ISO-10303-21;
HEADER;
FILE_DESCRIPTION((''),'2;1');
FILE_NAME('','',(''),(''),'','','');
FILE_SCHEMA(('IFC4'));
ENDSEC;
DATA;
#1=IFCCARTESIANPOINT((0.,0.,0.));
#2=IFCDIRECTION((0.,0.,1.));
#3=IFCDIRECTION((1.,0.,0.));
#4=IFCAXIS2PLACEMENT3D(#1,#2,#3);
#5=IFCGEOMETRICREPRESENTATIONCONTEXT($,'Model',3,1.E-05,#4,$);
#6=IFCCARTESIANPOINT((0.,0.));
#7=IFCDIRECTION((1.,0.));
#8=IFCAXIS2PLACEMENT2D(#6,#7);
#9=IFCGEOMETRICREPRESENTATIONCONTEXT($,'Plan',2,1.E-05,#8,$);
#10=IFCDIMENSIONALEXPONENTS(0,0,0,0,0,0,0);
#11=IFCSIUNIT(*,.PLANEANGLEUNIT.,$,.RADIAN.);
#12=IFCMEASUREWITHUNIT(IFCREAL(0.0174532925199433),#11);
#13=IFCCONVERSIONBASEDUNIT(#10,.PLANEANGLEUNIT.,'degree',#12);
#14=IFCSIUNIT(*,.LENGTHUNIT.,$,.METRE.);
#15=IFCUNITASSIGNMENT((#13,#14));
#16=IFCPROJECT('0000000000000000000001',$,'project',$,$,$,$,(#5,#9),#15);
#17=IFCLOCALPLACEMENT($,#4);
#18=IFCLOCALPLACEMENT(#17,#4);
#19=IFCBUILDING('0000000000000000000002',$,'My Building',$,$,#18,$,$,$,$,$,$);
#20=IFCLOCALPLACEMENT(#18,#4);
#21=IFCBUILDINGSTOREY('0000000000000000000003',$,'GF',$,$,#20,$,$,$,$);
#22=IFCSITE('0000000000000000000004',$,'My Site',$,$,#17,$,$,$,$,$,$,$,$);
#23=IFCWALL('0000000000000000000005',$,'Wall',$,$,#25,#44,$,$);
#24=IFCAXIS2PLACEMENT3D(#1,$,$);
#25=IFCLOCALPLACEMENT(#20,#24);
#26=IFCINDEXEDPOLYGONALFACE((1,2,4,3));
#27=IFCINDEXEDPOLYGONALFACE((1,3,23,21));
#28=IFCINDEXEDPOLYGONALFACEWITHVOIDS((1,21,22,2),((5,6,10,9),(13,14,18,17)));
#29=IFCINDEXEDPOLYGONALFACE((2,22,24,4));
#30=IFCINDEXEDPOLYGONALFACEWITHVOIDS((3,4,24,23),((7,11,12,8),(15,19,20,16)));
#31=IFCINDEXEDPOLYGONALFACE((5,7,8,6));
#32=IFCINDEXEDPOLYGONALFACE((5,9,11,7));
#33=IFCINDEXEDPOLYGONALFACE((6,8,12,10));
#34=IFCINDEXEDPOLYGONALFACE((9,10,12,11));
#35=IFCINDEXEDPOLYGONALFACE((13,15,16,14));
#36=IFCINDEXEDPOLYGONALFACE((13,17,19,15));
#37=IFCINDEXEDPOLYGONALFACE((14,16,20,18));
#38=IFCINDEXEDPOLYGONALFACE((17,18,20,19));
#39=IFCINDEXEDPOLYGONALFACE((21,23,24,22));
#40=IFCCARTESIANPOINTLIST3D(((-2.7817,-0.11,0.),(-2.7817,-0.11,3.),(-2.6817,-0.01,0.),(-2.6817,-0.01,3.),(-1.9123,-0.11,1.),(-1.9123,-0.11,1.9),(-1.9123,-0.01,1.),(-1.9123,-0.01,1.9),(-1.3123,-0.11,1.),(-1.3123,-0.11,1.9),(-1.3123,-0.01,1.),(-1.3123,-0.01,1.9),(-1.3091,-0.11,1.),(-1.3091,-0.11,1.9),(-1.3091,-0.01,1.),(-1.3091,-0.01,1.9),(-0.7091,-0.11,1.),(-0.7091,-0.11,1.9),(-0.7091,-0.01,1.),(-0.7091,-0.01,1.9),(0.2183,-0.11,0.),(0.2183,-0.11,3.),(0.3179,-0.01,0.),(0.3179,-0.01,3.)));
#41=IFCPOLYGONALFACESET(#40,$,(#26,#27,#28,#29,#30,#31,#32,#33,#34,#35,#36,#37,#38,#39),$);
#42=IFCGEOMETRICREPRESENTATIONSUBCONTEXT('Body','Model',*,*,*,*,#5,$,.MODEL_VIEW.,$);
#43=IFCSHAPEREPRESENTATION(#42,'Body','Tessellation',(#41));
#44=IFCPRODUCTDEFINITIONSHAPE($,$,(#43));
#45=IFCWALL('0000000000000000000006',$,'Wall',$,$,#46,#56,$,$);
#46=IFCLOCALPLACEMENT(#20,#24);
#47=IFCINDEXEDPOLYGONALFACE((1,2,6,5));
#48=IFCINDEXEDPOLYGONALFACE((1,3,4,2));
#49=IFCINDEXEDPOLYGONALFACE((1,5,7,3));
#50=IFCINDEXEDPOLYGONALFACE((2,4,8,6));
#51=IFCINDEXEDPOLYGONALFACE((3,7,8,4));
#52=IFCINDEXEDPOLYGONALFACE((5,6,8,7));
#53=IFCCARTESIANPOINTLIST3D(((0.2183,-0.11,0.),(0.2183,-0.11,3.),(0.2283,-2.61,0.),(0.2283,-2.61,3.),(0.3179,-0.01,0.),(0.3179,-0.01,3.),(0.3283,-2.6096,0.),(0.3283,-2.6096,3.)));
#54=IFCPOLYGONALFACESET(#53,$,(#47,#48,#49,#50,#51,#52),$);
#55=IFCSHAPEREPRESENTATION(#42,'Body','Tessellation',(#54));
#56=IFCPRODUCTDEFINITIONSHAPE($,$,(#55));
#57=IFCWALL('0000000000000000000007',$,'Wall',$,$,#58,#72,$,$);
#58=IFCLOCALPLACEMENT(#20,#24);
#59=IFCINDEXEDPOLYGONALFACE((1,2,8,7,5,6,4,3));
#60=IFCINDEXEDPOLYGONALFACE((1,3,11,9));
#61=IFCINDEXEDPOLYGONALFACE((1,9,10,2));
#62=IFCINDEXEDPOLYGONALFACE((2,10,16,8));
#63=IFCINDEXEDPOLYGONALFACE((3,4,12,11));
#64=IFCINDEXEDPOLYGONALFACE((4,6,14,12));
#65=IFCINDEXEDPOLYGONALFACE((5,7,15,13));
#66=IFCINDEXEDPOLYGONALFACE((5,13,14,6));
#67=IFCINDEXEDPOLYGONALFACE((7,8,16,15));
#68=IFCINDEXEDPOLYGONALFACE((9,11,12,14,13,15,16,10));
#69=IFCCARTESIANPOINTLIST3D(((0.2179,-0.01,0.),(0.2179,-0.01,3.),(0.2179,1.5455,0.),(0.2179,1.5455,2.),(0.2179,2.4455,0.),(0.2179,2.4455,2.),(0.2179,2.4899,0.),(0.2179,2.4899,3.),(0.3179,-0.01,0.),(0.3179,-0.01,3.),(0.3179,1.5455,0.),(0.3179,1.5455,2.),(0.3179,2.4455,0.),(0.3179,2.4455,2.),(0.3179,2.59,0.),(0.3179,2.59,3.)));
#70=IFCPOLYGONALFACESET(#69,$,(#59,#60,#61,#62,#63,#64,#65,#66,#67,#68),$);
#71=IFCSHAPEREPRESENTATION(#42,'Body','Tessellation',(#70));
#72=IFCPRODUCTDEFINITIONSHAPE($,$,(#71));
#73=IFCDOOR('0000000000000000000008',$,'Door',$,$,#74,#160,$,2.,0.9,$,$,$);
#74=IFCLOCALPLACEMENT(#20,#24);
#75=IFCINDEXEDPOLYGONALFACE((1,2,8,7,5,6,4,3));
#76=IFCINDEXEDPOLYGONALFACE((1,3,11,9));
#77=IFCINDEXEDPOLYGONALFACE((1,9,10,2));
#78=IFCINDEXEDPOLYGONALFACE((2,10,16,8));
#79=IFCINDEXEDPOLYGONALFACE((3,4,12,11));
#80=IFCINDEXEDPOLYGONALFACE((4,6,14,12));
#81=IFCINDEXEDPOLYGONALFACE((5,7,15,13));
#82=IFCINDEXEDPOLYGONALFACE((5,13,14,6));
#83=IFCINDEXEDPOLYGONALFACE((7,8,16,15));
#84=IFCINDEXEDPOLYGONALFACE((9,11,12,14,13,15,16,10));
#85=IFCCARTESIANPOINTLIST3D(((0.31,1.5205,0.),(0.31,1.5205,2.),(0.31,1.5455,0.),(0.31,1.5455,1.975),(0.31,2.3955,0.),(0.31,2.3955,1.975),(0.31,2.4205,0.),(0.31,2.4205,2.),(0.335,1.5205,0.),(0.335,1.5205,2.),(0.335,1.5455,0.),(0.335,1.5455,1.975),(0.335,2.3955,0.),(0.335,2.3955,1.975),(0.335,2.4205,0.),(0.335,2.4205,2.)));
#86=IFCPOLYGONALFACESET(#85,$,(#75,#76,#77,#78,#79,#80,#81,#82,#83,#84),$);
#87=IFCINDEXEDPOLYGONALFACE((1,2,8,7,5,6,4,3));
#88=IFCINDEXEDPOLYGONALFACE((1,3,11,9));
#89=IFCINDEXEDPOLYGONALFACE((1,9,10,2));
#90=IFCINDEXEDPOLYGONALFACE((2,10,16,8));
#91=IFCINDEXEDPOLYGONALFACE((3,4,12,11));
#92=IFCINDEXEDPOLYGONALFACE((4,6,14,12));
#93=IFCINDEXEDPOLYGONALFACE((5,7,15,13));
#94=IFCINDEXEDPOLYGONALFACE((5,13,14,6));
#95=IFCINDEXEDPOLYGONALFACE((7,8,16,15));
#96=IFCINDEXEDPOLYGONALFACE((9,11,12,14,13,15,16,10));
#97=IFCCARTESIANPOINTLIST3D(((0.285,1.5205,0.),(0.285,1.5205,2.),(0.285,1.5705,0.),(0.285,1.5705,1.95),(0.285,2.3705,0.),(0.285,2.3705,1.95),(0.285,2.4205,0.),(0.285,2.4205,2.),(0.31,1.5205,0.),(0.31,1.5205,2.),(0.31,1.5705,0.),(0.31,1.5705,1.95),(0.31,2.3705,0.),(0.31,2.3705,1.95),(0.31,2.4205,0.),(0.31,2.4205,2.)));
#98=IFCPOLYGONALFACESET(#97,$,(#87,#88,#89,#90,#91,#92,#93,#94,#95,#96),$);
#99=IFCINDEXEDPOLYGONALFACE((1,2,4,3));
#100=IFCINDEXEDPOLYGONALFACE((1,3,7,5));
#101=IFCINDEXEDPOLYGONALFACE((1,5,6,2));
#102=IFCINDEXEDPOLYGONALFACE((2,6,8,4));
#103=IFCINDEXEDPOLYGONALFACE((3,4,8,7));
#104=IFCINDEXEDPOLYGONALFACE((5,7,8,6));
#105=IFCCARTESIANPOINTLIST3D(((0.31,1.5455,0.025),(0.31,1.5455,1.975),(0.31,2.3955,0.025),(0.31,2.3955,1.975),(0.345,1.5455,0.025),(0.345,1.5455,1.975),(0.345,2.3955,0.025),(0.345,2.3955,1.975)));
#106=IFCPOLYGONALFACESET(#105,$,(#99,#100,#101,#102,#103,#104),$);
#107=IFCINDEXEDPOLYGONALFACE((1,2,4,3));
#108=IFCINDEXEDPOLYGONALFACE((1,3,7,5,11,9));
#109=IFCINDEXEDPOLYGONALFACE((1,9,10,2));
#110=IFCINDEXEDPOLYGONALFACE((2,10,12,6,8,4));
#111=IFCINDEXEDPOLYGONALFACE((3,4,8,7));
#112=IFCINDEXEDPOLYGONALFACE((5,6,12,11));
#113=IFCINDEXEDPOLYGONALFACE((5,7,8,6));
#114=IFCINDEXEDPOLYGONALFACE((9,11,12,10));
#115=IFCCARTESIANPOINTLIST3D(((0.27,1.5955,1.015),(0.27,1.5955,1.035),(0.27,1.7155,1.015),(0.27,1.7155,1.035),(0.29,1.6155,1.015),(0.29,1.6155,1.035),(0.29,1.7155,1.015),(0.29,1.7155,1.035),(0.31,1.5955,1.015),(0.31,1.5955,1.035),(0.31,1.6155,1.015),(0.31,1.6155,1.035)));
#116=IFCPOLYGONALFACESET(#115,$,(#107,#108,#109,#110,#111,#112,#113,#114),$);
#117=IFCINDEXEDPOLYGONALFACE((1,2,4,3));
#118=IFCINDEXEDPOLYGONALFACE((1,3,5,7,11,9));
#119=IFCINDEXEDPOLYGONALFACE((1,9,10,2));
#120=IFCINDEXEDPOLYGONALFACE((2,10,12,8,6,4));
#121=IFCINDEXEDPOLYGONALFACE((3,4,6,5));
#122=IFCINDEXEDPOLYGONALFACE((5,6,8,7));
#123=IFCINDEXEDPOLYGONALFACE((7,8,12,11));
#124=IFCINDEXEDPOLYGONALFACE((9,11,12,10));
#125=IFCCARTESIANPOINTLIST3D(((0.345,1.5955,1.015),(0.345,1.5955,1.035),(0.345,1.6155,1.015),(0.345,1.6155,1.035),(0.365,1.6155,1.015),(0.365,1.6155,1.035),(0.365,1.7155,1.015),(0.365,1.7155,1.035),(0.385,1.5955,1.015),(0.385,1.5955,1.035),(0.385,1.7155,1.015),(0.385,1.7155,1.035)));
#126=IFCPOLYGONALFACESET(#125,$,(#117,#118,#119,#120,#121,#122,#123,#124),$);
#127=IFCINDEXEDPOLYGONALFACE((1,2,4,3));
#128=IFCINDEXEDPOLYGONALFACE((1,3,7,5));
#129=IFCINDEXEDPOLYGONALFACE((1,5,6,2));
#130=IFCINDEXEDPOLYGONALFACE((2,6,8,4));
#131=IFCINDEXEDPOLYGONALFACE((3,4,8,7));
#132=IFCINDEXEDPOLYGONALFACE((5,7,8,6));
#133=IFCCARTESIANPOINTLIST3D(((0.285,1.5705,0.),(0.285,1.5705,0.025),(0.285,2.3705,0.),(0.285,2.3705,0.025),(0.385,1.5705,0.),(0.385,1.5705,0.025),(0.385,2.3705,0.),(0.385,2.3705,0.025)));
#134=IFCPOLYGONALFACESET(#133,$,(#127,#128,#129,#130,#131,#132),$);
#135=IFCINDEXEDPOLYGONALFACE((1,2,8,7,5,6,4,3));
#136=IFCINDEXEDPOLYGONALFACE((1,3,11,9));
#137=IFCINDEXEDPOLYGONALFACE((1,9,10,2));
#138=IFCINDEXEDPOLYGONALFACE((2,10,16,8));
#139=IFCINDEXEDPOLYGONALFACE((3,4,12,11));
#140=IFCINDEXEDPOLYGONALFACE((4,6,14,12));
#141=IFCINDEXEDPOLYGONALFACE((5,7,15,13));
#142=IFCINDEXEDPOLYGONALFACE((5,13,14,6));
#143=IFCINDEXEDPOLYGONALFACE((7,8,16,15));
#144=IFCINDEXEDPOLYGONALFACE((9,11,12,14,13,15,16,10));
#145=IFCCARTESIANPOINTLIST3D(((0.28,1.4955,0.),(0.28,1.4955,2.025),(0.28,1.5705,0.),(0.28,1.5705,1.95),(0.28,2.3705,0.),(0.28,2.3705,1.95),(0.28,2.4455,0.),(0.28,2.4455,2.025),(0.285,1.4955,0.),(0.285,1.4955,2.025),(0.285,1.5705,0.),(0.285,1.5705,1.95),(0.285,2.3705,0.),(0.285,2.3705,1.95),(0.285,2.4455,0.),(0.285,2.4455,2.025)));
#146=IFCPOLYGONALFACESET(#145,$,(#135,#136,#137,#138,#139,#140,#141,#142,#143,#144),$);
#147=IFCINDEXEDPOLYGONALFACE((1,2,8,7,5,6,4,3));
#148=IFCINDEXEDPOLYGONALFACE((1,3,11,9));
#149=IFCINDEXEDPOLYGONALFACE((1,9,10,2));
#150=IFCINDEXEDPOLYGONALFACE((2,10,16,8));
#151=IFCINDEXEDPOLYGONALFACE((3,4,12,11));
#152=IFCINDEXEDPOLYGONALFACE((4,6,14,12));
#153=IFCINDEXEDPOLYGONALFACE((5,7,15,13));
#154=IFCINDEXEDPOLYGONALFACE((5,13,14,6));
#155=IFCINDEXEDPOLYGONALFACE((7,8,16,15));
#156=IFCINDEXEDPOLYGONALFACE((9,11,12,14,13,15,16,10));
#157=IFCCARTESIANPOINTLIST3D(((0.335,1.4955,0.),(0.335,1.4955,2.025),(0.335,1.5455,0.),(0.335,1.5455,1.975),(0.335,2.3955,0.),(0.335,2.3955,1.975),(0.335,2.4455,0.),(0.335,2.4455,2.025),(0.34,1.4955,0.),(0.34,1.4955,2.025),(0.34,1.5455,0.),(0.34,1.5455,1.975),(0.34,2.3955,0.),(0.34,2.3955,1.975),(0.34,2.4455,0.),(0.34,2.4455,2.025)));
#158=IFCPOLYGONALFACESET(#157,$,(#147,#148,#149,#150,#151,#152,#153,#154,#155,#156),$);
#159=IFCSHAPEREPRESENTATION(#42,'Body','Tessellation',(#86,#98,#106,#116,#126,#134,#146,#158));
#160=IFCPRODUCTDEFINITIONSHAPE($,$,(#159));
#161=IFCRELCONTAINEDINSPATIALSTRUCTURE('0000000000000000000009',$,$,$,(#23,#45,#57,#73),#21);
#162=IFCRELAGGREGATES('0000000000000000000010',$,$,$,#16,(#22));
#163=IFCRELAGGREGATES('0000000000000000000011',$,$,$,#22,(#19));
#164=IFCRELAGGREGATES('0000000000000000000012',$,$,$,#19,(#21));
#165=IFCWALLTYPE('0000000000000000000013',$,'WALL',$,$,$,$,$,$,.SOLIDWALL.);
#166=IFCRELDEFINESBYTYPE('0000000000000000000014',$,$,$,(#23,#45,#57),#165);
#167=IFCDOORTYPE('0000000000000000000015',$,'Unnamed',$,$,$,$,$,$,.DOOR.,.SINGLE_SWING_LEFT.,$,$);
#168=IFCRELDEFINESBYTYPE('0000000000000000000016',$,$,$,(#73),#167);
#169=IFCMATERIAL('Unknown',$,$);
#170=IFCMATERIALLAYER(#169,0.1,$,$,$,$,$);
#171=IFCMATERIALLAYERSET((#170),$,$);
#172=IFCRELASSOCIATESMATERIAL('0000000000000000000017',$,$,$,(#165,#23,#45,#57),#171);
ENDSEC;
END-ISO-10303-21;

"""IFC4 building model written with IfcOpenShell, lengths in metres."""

from ifc_helpers import new_model, entity, si_unit, converted_unit, frame, origin_with_axes, origin_2d_with_axis, place, context, subcontext, project, spatial, line, indexed_curve, outline, extrude, shape, source, transform, mapped, material, layer, layer_set, layer_usage, type_object, type_shapes, element, fill, save


model = new_model("IFC4")

# Units and contexts
model_context = context("Model", 3, precision=1e-05, world=origin_with_axes())
plan_context = context("Plan", 2, precision=1e-05, world=origin_2d_with_axis())
body_context_1 = subcontext(model_context, "Body", "Model", "MODEL_VIEW")
body_context_2 = subcontext(plan_context, "Body", "Plan", "PLAN_VIEW")
ifc_project = project(units=[converted_unit("PLANEANGLEUNIT", "degree", entity("IfcReal", 0.0174532925199433), si_unit("PLANEANGLEUNIT", "RADIAN"), dimensions=[0, 0, 0, 0, 0, 0, 0]), si_unit("LENGTHUNIT", "METRE")], contexts=[model_context, plan_context])

# Site, building, storey
site_placement = place(None, origin_with_axes())
site = spatial("IfcSite", under=ifc_project, at=site_placement, Name="My Site")
building_placement = place(site_placement, origin_with_axes())
building = spatial("IfcBuilding", under=site, at=building_placement, Name="My Building")
storey_placement = place(building_placement, origin_with_axes())
storey = spatial("IfcBuildingStorey", under=building, at=storey_placement, Name="GF")

# Shared definitions
ifc_material = material(Name="Unknown")

# Shared definitions
ifc_layer_1 = layer(ifc_material, 0.1)
ifc_layer_set_1 = layer_set([ifc_layer_1])
wall_type = type_object("IfcWallType", Name="WALL", PredefinedType="SOLIDWALL", material=ifc_layer_set_1)
shared_shape_1 = source(origin_with_axes(), body_context_1, "Body", "SweptSolid", [
    extrude(outline(indexed_curve([(0.0, 0.0), (0.9, 0.0), (0.9, 2.0), (0.0, 2.0)], segments=[line(1, 2, 3, 4, 1)])), frame((0.0, -0.6, 0.0), z_axis=(0.0, -1.0, 0.0), x_axis=(1.0, 0.0, 0.0)), (0.0, 0.0, -1.0), 1.2),
])
door_type = type_object("IfcDoorType", Name="Unnamed", OperationType="SINGLE_SWING_LEFT", PredefinedType="DOOR")
shared_shape_2 = source(origin_with_axes(), body_context_1, "Body", "SweptSolid", [
    extrude(outline(indexed_curve([(0.0, 0.0), (0.0, 2.0), (0.9, 2.0), (0.9, 0.0), (0.875, 0.0), (0.875, 1.975), (0.025, 1.975), (0.025, 0.0)], segments=[line(1, 2, 3, 4, 5, 6, 7, 8, 1)])), frame((0.0, 0.025, 0.0), z_axis=(0.0, -1.0, 0.0), x_axis=(1.0, 0.0, 0.0)), (0.0, 0.0, -1.0), 0.025),
    extrude(outline(indexed_curve([(0.0, 0.0), (0.0, 2.0), (0.9, 2.0), (0.9, 0.0), (0.85, 0.0), (0.85, 1.95), (0.05, 1.95), (0.05, 0.0)], segments=[line(1, 2, 3, 4, 5, 6, 7, 8, 1)])), frame((0.0, 0.0, 0.0), z_axis=(0.0, -1.0, 0.0), x_axis=(1.0, 0.0, 0.0)), (0.0, 0.0, -1.0), 0.025),
    extrude(outline(indexed_curve([(0.0, 0.0), (0.85, 0.0), (0.85, 0.035), (0.0, 0.035)], segments=[line(1, 2, 3, 4, 1)])), frame((0.025, 0.025, 0.025), z_axis=(0.0, 0.0, 1.0), x_axis=(1.0, 0.0, 0.0)), (0.0, 0.0, 1.0), 1.95),
    extrude(outline(indexed_curve([(0.0, 0.0), (0.0, -0.04), (-0.12, -0.04), (-0.12, -0.02), (-0.02, -0.02), (-0.02, 0.0)], segments=[line(1, 2, 3, 4, 5, 6, 1)])), frame((0.825, 0.025, 1.015), z_axis=(0.0, 0.0, 1.0), x_axis=(1.0, 0.0, 0.0)), (0.0, 0.0, 1.0), 0.02),
    extrude(outline(indexed_curve([(0.0, 0.0), (0.0, 0.04), (-0.12, 0.04), (-0.12, 0.02), (-0.02, 0.02), (-0.02, 0.0)], segments=[line(1, 2, 3, 4, 5, 6, 1)])), frame((0.825, 0.06, 1.015), z_axis=(0.0, 0.0, 1.0), x_axis=(1.0, 0.0, 0.0)), (0.0, 0.0, 1.0), 0.02),
    extrude(outline(indexed_curve([(0.0, 0.0), (0.8, 0.0), (0.8, 0.1), (0.0, 0.1)], segments=[line(1, 2, 3, 4, 1)])), frame((0.05, 0.0, 0.0), z_axis=(0.0, 0.0, 1.0), x_axis=(1.0, 0.0, 0.0)), (0.0, 0.0, 1.0), 0.025),
    extrude(outline(indexed_curve([(0.0, 0.0), (0.0, 2.025), (0.95, 2.025), (0.95, 0.0), (0.875, 0.0), (0.875, 1.95), (0.075, 1.95), (0.075, 0.0)], segments=[line(1, 2, 3, 4, 5, 6, 7, 8, 1)])), frame((-0.025, -0.005, 0.0), z_axis=(0.0, -1.0, 0.0), x_axis=(1.0, 0.0, 0.0)), (0.0, 0.0, -1.0), 0.005),
    extrude(outline(indexed_curve([(0.0, 0.0), (0.0, 2.025), (0.95, 2.025), (0.95, 0.0), (0.9, 0.0), (0.9, 1.975), (0.05, 1.975), (0.05, 0.0)], segments=[line(1, 2, 3, 4, 5, 6, 7, 8, 1)])), frame((-0.025, 0.05, 0.0), z_axis=(0.0, -1.0, 0.0), x_axis=(1.0, 0.0, 0.0)), (0.0, 0.0, -1.0), 0.005),
])
shared_shape_3 = source(origin_with_axes(), body_context_2, "Body", "Curve2D", [
    entity("IfcIndexedPolyCurve", entity("IfcCartesianPointList2D", [[0.0, 0.0], [0.0, 0.05], [0.025, 0.05], [0.025, 0.025], [0.05, 0.025], [0.05, 0.0]]), [entity("IfcLineIndex", [1, 2, 3, 4, 5, 6, 1])]),
    entity("IfcIndexedPolyCurve", entity("IfcCartesianPointList2D", [[0.9, 0.0], [0.9, 0.05], [0.875, 0.05], [0.875, 0.025], [0.85, 0.025], [0.85, 0.0]]), [entity("IfcLineIndex", [1, 2, 3, 4, 5, 6, 1])]),
    entity("IfcTrimmedCurve", entity("IfcEllipse", entity("IfcAxis2Placement2D", entity("IfcCartesianPoint", [0.06, 0.05]), entity("IfcDirection", [1.0, 0.0])), 0.815, 0.85), [entity("IfcCartesianPoint", [0.875, 0.05])], [entity("IfcCartesianPoint", [0.06, 0.9])], True, "CARTESIAN"),
    entity("IfcIndexedPolyCurve", entity("IfcCartesianPointList2D", [[0.025, 0.05], [0.06, 0.05], [0.06, 0.9], [0.025, 0.9]]), [entity("IfcLineIndex", [1, 2, 3, 4, 1])]),
])
type_shapes(door_type, [shared_shape_2, shared_shape_3])

# Shared definitions
shared_shape_4 = source(origin_with_axes(), body_context_1, "Body", "SweptSolid", [
    extrude(outline(indexed_curve([(0.0, 0.0), (0.6, 0.0), (0.6, 0.9), (0.0, 0.9)], segments=[line(1, 2, 3, 4, 1)])), frame((0.0, -0.6, 0.0), z_axis=(0.0, -1.0, 0.0), x_axis=(1.0, 0.0, 0.0)), (0.0, 0.0, -1.0), 1.2),
])

# Wall, openings
ifc_layer_usage_1 = layer_usage(ifc_layer_set_1, "AXIS2", "POSITIVE", 0.0)
wall_1_placement = place(storey_placement, frame((-2.7817, -0.11, 0.0), z_axis=(0.0, 0.0, 1.0), x_axis=(1.0, 0.0, 0.0)))
wall_1 = element("IfcWall", 1, at=wall_1_placement, inside=storey, type_object=wall_type, material=ifc_layer_usage_1, Name="Wall", context=body_context_1, shape_type="SweptSolid", body=[
    extrude(outline(indexed_curve([(0.0, 0.0), (0.1, 0.1), (3.0996, 0.1), (3.0, 0.0)], segments=[line(1, 2, 3, 4, 1)])), origin_with_axes(), (0.0, 0.0, 1.0), 3.0),
])
opening_1_placement = place(wall_1_placement, frame((0.8694, 0.0, 1.0), z_axis=(0.0, 0.0, 1.0), x_axis=(1.0, 0.0, 0.0)))
element("IfcOpeningElement", 2, at=opening_1_placement, cuts=wall_1, PredefinedType="OPENING", context=body_context_1, shape_type="MappedRepresentation", body=[
    mapped(shared_shape_4, transform((0.0, 0.0, 0.0), x_axis=(1.0, 0.0, 0.0), y_axis=(0.0, 1.0, 0.0), z_axis=(0.0, 0.0, 1.0), scale=1.0)),
])
opening_2_placement = place(wall_1_placement, frame((1.4725, 0.0, 1.0), z_axis=(0.0, 0.0, 1.0), x_axis=(1.0, 0.0, 0.0)))
element("IfcOpeningElement", 3, at=opening_2_placement, cuts=wall_1, PredefinedType="OPENING", context=body_context_1, shape_type="MappedRepresentation", body=[
    mapped(shared_shape_4, transform((0.0, 0.0, 0.0), x_axis=(1.0, 0.0, 0.0), y_axis=(0.0, 1.0, 0.0), z_axis=(0.0, 0.0, 1.0), scale=1.0)),
])

# Wall
ifc_layer_usage_2 = layer_usage(ifc_layer_set_1, "AXIS2", "POSITIVE", 0.0)
wall_2_placement = place(storey_placement, frame((0.2183, -0.11, 0.0), z_axis=(0.0, 0.0, 1.0), x_axis=(0.004, -0.999992, 0.0)))
element("IfcWall", 4, at=wall_2_placement, inside=storey, type_object=wall_type, material=ifc_layer_usage_2, Name="Wall", context=body_context_1, shape_type="SweptSolid", body=[
    extrude(outline(indexed_curve([(0.0, 0.0), (-0.0996, 0.1), (2.5, 0.1), (2.5, 0.0)], segments=[line(1, 2, 3, 4, 1)])), origin_with_axes(), (0.0, 0.0, 1.0), 3.0),
])

# Wall, opening, door
ifc_layer_usage_3 = layer_usage(ifc_layer_set_1, "AXIS2", "POSITIVE", 0.0)
wall_3_placement = place(storey_placement, frame((0.3179, -0.01, 0.0), z_axis=(0.0, 0.0, 1.0), x_axis=(0.0, 1.0, 0.0)))
wall_3 = element("IfcWall", 5, at=wall_3_placement, inside=storey, type_object=wall_type, material=ifc_layer_usage_3, Name="Wall", context=body_context_1, shape_type="SweptSolid", body=[
    extrude(outline(indexed_curve([(0.0, 0.0), (0.0, 0.1), (2.5, 0.1), (2.6, 0.0)], segments=[line(1, 2, 3, 4, 1)])), origin_with_axes(), (0.0, 0.0, 1.0), 3.0),
])
opening_3_placement = place(wall_3_placement, frame((1.5555, 0.0, 0.0), z_axis=(0.0, 0.0, 1.0), x_axis=(1.0, 0.0, 0.0)))
opening_3 = element("IfcOpeningElement", 6, at=opening_3_placement, cuts=wall_3, PredefinedType="OPENING", context=body_context_1, shape_type="MappedRepresentation", body=[
    mapped(shared_shape_1, transform((0.0, 0.0, 0.0), x_axis=(1.0, 0.0, 0.0), y_axis=(0.0, 1.0, 0.0), z_axis=(0.0, 0.0, 1.0), scale=1.0)),
])
door_1_placement = place(opening_3_placement, frame((0.875, 0.033, 0.0), z_axis=(0.0, 0.0, 1.0), x_axis=(-1.0, 0.0, 0.0)))
door_1 = element("IfcDoor", 7, at=door_1_placement, inside=storey, type_object=door_type, Name="Door", OverallHeight=2.0, OverallWidth=0.9, shapes=[
    shape(body_context_1, "Body", "MappedRepresentation", [mapped(shared_shape_2, transform((0.0, 0.0, 0.0), x_axis=(1.0, 0.0, 0.0), y_axis=(0.0, 1.0, 0.0), z_axis=(0.0, 0.0, 1.0), scale=1.0))]),
    shape(body_context_2, "Body", "MappedRepresentation", [mapped(shared_shape_3, transform((0.0, 0.0, 0.0), x_axis=(1.0, 0.0, 0.0), y_axis=(0.0, 1.0, 0.0), z_axis=(0.0, 0.0, 1.0), scale=1.0))]),
])
fill(opening_3, door_1)

save(model, "model.ifc")
